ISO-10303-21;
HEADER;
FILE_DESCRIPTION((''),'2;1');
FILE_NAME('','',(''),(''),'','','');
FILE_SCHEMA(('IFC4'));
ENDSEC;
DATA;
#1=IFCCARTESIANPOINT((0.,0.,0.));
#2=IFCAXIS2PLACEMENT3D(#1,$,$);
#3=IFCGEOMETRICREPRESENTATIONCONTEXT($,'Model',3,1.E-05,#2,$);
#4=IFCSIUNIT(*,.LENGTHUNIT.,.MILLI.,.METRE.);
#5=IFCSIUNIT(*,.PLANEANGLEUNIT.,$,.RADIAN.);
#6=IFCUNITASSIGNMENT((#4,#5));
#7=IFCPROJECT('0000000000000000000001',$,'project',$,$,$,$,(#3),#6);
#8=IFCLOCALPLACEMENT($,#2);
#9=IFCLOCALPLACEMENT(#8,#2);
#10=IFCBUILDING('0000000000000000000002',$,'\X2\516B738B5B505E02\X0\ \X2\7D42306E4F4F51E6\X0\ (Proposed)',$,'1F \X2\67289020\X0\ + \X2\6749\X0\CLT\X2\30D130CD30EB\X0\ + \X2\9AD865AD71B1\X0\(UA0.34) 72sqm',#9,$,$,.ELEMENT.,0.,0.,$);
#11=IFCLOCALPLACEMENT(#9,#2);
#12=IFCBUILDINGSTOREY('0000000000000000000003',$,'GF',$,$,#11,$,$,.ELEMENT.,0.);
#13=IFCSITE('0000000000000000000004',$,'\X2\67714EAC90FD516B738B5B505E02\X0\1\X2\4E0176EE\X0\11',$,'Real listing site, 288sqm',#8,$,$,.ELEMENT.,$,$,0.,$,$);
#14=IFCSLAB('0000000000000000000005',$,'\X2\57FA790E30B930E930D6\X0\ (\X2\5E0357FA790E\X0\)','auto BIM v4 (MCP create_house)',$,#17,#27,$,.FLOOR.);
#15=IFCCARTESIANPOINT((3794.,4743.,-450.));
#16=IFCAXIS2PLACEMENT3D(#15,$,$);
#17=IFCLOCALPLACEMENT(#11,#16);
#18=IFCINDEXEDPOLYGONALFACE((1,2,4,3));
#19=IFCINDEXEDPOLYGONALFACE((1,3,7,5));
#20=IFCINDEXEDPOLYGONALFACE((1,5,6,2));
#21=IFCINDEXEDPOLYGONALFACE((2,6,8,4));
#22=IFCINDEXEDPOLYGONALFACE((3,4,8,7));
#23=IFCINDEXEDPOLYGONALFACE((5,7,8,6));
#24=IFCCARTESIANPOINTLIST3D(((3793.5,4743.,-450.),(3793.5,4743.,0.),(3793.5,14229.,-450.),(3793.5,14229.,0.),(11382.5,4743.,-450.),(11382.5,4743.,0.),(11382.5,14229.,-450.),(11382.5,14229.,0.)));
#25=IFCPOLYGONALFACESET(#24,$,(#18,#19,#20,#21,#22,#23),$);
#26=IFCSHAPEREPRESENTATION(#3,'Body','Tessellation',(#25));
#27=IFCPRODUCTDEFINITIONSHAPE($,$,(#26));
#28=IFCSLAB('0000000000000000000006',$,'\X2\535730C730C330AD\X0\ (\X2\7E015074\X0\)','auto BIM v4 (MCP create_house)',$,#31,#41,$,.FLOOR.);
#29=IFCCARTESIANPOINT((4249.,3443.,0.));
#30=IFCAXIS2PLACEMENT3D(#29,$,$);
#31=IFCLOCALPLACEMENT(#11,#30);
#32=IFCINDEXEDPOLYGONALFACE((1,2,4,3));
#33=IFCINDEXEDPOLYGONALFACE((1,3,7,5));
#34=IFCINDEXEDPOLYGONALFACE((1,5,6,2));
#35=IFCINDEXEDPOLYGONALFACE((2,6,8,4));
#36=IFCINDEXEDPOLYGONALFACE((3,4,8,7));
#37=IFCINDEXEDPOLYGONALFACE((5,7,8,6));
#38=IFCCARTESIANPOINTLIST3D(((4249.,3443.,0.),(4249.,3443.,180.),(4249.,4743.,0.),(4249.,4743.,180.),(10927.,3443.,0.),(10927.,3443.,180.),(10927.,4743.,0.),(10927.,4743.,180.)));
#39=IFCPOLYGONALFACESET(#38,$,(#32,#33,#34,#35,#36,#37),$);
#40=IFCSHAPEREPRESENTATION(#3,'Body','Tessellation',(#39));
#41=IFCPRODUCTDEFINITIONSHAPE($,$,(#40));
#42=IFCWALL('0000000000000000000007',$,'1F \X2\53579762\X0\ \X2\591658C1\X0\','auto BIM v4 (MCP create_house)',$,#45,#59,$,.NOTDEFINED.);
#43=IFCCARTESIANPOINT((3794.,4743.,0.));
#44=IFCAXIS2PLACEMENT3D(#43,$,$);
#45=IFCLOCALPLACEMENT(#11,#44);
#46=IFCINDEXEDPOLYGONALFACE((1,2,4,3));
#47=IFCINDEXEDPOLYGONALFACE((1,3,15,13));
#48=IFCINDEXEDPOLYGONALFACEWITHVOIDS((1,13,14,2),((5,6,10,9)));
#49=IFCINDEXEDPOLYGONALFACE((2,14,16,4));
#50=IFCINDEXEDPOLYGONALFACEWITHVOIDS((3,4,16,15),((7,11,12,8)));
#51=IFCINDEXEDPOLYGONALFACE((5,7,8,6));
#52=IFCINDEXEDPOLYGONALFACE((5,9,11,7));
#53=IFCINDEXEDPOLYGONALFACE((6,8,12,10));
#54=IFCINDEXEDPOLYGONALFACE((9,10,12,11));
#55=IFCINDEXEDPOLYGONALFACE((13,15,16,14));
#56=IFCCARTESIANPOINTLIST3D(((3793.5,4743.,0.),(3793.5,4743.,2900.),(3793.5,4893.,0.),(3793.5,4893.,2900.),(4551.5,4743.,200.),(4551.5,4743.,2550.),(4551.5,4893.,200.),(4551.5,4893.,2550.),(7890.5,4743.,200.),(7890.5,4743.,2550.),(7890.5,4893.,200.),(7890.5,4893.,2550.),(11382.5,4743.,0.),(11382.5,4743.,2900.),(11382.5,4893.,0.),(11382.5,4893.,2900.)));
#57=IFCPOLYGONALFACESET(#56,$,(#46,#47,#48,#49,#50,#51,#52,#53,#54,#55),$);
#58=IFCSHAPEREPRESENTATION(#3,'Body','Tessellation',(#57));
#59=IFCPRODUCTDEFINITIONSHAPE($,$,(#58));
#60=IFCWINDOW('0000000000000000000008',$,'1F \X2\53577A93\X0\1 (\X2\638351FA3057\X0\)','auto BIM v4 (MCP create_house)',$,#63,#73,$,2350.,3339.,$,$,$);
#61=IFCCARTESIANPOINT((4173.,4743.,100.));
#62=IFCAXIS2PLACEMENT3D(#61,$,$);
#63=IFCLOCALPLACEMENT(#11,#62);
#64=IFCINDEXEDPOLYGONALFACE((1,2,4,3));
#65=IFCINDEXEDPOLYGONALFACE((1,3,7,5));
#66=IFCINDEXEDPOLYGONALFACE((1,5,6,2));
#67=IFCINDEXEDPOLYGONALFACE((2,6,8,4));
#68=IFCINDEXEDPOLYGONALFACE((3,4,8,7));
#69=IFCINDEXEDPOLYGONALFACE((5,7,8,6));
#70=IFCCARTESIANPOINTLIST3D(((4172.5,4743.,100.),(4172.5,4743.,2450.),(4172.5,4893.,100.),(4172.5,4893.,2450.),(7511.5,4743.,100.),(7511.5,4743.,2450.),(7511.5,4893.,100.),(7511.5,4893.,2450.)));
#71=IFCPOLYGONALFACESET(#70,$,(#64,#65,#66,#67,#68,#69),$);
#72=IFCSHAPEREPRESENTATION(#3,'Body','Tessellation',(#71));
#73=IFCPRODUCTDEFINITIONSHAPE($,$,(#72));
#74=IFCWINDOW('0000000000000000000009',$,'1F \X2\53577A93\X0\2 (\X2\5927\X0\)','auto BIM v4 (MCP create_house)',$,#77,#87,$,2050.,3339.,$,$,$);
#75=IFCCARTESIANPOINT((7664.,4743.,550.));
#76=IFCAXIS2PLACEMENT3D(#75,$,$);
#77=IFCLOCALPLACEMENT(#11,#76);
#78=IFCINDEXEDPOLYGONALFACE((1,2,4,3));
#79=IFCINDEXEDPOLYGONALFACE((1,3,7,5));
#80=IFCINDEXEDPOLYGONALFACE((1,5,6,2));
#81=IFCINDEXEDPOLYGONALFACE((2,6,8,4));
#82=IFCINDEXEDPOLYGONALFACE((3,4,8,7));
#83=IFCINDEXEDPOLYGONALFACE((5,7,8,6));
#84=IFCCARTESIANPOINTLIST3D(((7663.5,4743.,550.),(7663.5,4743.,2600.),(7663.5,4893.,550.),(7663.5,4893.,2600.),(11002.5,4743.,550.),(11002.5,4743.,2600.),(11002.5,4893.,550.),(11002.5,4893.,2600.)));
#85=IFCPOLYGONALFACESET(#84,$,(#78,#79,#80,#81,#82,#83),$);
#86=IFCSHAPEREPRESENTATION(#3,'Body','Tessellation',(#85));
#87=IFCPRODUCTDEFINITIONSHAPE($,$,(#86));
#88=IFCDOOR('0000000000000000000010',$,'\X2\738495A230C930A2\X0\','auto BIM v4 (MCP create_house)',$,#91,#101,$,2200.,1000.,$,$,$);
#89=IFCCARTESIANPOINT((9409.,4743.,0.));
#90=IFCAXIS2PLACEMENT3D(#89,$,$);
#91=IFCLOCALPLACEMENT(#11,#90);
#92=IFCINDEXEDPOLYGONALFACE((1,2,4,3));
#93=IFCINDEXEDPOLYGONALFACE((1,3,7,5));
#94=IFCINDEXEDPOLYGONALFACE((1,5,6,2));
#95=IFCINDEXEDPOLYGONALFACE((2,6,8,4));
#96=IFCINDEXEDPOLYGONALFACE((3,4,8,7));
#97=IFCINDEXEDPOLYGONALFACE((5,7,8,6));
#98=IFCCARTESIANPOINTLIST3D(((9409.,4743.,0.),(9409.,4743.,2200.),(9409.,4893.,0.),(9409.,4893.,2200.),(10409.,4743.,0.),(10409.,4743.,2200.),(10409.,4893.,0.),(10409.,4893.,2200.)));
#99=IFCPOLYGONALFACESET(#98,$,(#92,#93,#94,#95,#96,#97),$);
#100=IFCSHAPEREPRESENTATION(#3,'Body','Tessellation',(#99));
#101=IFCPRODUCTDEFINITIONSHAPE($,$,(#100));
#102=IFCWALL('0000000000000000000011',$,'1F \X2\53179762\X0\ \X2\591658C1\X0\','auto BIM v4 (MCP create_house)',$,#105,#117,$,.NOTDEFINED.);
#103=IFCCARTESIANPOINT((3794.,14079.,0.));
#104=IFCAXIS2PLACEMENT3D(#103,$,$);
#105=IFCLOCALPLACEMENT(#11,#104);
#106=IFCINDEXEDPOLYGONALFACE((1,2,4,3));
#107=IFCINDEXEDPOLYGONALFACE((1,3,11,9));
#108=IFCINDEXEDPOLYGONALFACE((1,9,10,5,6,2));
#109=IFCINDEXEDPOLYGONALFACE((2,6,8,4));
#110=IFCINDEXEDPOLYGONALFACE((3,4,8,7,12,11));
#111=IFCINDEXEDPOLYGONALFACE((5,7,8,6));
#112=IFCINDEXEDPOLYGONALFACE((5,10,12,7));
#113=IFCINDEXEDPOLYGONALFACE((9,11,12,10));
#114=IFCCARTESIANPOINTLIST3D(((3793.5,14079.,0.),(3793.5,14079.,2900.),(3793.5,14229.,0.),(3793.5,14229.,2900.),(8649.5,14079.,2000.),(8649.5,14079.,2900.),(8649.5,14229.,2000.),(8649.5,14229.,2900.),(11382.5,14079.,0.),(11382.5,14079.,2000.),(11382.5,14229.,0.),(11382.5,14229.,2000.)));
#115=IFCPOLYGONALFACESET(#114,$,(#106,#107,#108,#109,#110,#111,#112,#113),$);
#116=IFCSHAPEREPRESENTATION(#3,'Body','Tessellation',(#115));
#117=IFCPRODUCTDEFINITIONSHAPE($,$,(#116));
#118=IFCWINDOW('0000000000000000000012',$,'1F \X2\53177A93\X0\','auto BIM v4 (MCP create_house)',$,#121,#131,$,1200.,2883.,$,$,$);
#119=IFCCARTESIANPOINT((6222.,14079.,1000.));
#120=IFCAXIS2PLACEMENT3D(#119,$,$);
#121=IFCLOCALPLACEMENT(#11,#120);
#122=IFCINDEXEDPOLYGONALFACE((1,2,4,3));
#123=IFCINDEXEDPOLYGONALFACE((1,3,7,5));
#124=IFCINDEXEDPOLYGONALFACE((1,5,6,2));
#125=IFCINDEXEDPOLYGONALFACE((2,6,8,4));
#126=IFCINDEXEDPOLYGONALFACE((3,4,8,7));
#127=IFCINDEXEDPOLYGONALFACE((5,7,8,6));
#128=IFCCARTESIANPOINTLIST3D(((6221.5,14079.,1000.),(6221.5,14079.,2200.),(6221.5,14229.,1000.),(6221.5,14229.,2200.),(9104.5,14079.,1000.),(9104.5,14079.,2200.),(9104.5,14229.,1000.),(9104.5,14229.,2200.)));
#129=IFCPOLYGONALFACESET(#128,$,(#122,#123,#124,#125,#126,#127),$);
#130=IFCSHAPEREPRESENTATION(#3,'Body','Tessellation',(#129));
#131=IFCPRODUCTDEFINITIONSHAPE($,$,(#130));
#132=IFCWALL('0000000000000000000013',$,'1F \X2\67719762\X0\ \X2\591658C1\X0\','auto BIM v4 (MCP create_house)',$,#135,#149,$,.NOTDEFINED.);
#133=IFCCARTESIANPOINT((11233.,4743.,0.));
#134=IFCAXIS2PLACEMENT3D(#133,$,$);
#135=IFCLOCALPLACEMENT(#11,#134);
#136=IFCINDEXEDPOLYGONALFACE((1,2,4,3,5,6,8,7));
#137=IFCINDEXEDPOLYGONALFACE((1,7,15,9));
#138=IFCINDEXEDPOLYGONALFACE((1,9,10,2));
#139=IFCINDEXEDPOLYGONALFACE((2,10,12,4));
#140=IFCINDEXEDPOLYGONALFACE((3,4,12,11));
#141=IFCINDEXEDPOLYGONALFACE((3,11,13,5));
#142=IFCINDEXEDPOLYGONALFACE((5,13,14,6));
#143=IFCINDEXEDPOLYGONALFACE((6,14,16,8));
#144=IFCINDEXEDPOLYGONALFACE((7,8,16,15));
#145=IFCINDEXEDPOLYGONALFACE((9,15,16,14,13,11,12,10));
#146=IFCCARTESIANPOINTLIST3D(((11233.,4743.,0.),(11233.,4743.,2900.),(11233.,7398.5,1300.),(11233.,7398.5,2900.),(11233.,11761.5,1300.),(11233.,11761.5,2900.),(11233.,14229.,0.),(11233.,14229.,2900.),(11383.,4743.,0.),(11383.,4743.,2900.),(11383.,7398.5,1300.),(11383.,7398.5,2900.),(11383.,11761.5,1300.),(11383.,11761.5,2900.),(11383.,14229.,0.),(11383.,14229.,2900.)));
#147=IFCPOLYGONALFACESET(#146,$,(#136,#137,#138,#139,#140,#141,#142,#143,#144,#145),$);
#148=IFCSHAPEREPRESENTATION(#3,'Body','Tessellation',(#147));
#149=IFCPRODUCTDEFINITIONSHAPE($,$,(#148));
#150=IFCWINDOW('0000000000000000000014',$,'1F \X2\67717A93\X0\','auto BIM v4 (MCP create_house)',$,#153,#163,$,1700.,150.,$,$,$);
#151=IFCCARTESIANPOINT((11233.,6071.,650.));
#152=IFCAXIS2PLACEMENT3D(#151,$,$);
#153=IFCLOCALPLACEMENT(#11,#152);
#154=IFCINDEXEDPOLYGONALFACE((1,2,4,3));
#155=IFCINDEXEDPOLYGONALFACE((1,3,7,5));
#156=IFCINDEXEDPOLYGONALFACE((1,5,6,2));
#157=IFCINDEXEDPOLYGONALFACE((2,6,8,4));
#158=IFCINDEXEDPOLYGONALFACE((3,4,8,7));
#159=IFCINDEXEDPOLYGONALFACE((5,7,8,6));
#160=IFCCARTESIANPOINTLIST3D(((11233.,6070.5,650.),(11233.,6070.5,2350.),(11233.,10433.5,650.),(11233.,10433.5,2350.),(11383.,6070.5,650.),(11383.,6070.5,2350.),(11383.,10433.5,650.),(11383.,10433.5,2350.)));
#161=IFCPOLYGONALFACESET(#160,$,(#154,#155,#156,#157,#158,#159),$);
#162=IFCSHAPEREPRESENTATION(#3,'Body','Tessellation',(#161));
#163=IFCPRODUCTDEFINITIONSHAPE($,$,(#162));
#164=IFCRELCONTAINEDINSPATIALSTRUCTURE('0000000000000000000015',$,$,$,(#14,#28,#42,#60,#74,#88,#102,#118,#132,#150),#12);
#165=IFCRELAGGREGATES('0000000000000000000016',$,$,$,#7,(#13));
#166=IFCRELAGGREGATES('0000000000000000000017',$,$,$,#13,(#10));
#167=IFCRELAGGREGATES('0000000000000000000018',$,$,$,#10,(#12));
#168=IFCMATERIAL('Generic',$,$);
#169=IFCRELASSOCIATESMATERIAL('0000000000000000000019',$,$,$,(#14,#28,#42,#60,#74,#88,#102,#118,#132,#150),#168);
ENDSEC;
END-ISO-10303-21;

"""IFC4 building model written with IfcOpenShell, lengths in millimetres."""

from ifc_helpers import new_model, si_unit, frame, frame_2d, origin, place, context, project, spatial, rectangle, extrude, material, element, fill, save


model = new_model("IFC4")

# Units and contexts
model_context = context("Model", 3, precision=1e-05, world=origin())
ifc_project = project(units=[si_unit("LENGTHUNIT", "METRE", prefix="MILLI"), si_unit("PLANEANGLEUNIT", "RADIAN")], contexts=[model_context])

# Site, building, storey
site_placement = place(None, origin())
site = spatial("IfcSite", under=ifc_project, at=site_placement, Name="東京都八王子市1丁目11", ObjectType="Real listing site, 288sqm", CompositionType="ELEMENT", RefElevation=0.0)
building_placement = place(site_placement, origin())
building = spatial("IfcBuilding", under=site, at=building_placement, Name="八王子市 終の住処 (Proposed)", ObjectType="1F 木造 + 杉CLTパネル + 高断熱(UA0.34) 72sqm", CompositionType="ELEMENT", ElevationOfRefHeight=0.0, ElevationOfTerrain=0.0)
storey_placement = place(building_placement, origin())
storey = spatial("IfcBuildingStorey", under=building, at=storey_placement, Name="GF", CompositionType="ELEMENT", Elevation=0.0)

# Slabs
ifc_material = material(Name="Generic")
slab_1_placement = place(storey_placement, frame((3794.0, 4743.0, -450.0)))
element("IfcSlab", 1, at=slab_1_placement, inside=storey, material=ifc_material, Name="基礎スラブ (布基礎)", Description="auto BIM v4 (MCP create_house)", PredefinedType="FLOOR", context=model_context, shape_type="SweptSolid", body=[
    extrude(rectangle(XDim=7589.0, YDim=9486.0, at=frame_2d((3794.0, 4743.0))), frame((3794.0, 4743.0, -450.0)), (0.0, 0.0, 1.0), 450.0),
])
slab_2_placement = place(storey_placement, frame((4249.0, 3443.0, 0.0)))
element("IfcSlab", 2, at=slab_2_placement, inside=storey, material=ifc_material, Name="南デッキ (縁側)", Description="auto BIM v4 (MCP create_house)", PredefinedType="FLOOR", context=model_context, shape_type="SweptSolid", body=[
    extrude(rectangle(XDim=6678.0, YDim=1300.0, at=frame_2d((3339.0, 650.0))), frame((4249.0, 3443.0, 0.0)), (0.0, 0.0, 1.0), 180.0),
])

# Wall, openings, windows, door
wall_1_placement = place(storey_placement, frame((3794.0, 4743.0, 0.0)))
wall_1 = element("IfcWall", 3, at=wall_1_placement, inside=storey, material=ifc_material, Name="1F 南面 外壁", Description="auto BIM v4 (MCP create_house)", PredefinedType="NOTDEFINED", context=model_context, shape_type="SweptSolid", body=[
    extrude(rectangle(XDim=7589.0, YDim=150.0, at=frame_2d((3794.0, 75.0))), frame((3794.0, 4743.0, 0.0)), (0.0, 0.0, 1.0), 2900.0),
])
opening_1_placement = place(storey_placement, frame((4173.0, 4743.0, 100.0)))
opening_1 = element("IfcOpeningElement", 4, at=opening_1_placement, cuts=wall_1, PredefinedType="NOTDEFINED", context=model_context, shape_type="SweptSolid", body=[
    extrude(rectangle(XDim=3339.0, YDim=150.0, at=frame_2d((1669.0, 75.0))), frame((4173.0, 4743.0, 100.0)), (0.0, 0.0, 1.0), 2350.0),
])
opening_2_placement = place(storey_placement, frame((7664.0, 4743.0, 550.0)))
opening_2 = element("IfcOpeningElement", 5, at=opening_2_placement, cuts=wall_1, PredefinedType="NOTDEFINED", context=model_context, shape_type="SweptSolid", body=[
    extrude(rectangle(XDim=3339.0, YDim=150.0, at=frame_2d((1669.0, 75.0))), frame((7664.0, 4743.0, 550.0)), (0.0, 0.0, 1.0), 2050.0),
])
opening_3_placement = place(storey_placement, frame((9409.0, 4743.0, 0.0)))
opening_3 = element("IfcOpeningElement", 6, at=opening_3_placement, cuts=wall_1, PredefinedType="NOTDEFINED", context=model_context, shape_type="SweptSolid", body=[
    extrude(rectangle(XDim=1000.0, YDim=150.0, at=frame_2d((500.0, 75.0))), frame((9409.0, 4743.0, 0.0)), (0.0, 0.0, 1.0), 2200.0),
])
window_1_placement = place(storey_placement, frame((4173.0, 4743.0, 100.0)))
window_1 = element("IfcWindow", 7, at=window_1_placement, inside=storey, material=ifc_material, Name="1F 南窓1 (掃出し)", Description="auto BIM v4 (MCP create_house)", OverallHeight=2350.0, OverallWidth=3339.0, context=model_context, shape_type="SweptSolid", body=[
    extrude(rectangle(XDim=3339.0, YDim=150.0, at=frame_2d((1669.0, 75.0))), frame((4173.0, 4743.0, 100.0)), (0.0, 0.0, 1.0), 2350.0),
])
fill(opening_1, window_1)
window_2_placement = place(storey_placement, frame((7664.0, 4743.0, 550.0)))
window_2 = element("IfcWindow", 8, at=window_2_placement, inside=storey, material=ifc_material, Name="1F 南窓2 (大)", Description="auto BIM v4 (MCP create_house)", OverallHeight=2050.0, OverallWidth=3339.0, context=model_context, shape_type="SweptSolid", body=[
    extrude(rectangle(XDim=3339.0, YDim=150.0, at=frame_2d((1669.0, 75.0))), frame((7664.0, 4743.0, 550.0)), (0.0, 0.0, 1.0), 2050.0),
])
fill(opening_2, window_2)
door_placement = place(storey_placement, frame((9409.0, 4743.0, 0.0)))
door = element("IfcDoor", 9, at=door_placement, inside=storey, material=ifc_material, Name="玄関ドア", Description="auto BIM v4 (MCP create_house)", OverallHeight=2200.0, OverallWidth=1000.0, context=model_context, shape_type="SweptSolid", body=[
    extrude(rectangle(XDim=1000.0, YDim=150.0, at=frame_2d((500.0, 75.0))), frame((9409.0, 4743.0, 0.0)), (0.0, 0.0, 1.0), 2200.0),
])
fill(opening_3, door)

# Walls, openings, windows
wall_2_placement = place(storey_placement, frame((3794.0, 14079.0, 0.0)))
wall_2 = element("IfcWall", 10, at=wall_2_placement, inside=storey, material=ifc_material, Name="1F 北面 外壁", Description="auto BIM v4 (MCP create_house)", PredefinedType="NOTDEFINED", context=model_context, shape_type="SweptSolid", body=[
    extrude(rectangle(XDim=7589.0, YDim=150.0, at=frame_2d((3794.0, 75.0))), frame((3794.0, 14079.0, 0.0)), (0.0, 0.0, 1.0), 2900.0),
])
opening_4_placement = place(storey_placement, frame((6222.0, 14079.0, 1000.0)))
opening_4 = element("IfcOpeningElement", 11, at=opening_4_placement, cuts=wall_2, PredefinedType="NOTDEFINED", context=model_context, shape_type="SweptSolid", body=[
    extrude(rectangle(XDim=2883.0, YDim=150.0, at=frame_2d((1441.0, 75.0))), frame((6222.0, 14079.0, 1000.0)), (0.0, 0.0, 1.0), 1200.0),
])
window_3_placement = place(storey_placement, frame((6222.0, 14079.0, 1000.0)))
window_3 = element("IfcWindow", 12, at=window_3_placement, inside=storey, material=ifc_material, Name="1F 北窓", Description="auto BIM v4 (MCP create_house)", OverallHeight=1200.0, OverallWidth=2883.0, context=model_context, shape_type="SweptSolid", body=[
    extrude(rectangle(XDim=2883.0, YDim=150.0, at=frame_2d((1441.0, 75.0))), frame((6222.0, 14079.0, 1000.0)), (0.0, 0.0, 1.0), 1200.0),
])
fill(opening_4, window_3)
wall_3_placement = place(storey_placement, frame((11233.0, 4743.0, 0.0)))
wall_3 = element("IfcWall", 13, at=wall_3_placement, inside=storey, material=ifc_material, Name="1F 東面 外壁", Description="auto BIM v4 (MCP create_house)", PredefinedType="NOTDEFINED", context=model_context, shape_type="SweptSolid", body=[
    extrude(rectangle(XDim=150.0, YDim=9486.0, at=frame_2d((75.0, 4743.0))), frame((11233.0, 4743.0, 0.0)), (0.0, 0.0, 1.0), 2900.0),
])
opening_5_placement = place(storey_placement, frame((11233.0, 6071.0, 650.0)))
opening_5 = element("IfcOpeningElement", 14, at=opening_5_placement, cuts=wall_3, PredefinedType="NOTDEFINED", context=model_context, shape_type="SweptSolid", body=[
    extrude(rectangle(XDim=150.0, YDim=4363.0, at=frame_2d((75.0, 2181.0))), frame((11233.0, 6071.0, 650.0)), (0.0, 0.0, 1.0), 1700.0),
])
window_4_placement = place(storey_placement, frame((11233.0, 6071.0, 650.0)))
window_4 = element("IfcWindow", 15, at=window_4_placement, inside=storey, material=ifc_material, Name="1F 東窓", Description="auto BIM v4 (MCP create_house)", OverallHeight=1700.0, OverallWidth=150.0, context=model_context, shape_type="SweptSolid", body=[
    extrude(rectangle(XDim=150.0, YDim=4363.0, at=frame_2d((75.0, 2181.0))), frame((11233.0, 6071.0, 650.0)), (0.0, 0.0, 1.0), 1700.0),
])
fill(opening_5, window_4)

save(model, "model.ifc")
